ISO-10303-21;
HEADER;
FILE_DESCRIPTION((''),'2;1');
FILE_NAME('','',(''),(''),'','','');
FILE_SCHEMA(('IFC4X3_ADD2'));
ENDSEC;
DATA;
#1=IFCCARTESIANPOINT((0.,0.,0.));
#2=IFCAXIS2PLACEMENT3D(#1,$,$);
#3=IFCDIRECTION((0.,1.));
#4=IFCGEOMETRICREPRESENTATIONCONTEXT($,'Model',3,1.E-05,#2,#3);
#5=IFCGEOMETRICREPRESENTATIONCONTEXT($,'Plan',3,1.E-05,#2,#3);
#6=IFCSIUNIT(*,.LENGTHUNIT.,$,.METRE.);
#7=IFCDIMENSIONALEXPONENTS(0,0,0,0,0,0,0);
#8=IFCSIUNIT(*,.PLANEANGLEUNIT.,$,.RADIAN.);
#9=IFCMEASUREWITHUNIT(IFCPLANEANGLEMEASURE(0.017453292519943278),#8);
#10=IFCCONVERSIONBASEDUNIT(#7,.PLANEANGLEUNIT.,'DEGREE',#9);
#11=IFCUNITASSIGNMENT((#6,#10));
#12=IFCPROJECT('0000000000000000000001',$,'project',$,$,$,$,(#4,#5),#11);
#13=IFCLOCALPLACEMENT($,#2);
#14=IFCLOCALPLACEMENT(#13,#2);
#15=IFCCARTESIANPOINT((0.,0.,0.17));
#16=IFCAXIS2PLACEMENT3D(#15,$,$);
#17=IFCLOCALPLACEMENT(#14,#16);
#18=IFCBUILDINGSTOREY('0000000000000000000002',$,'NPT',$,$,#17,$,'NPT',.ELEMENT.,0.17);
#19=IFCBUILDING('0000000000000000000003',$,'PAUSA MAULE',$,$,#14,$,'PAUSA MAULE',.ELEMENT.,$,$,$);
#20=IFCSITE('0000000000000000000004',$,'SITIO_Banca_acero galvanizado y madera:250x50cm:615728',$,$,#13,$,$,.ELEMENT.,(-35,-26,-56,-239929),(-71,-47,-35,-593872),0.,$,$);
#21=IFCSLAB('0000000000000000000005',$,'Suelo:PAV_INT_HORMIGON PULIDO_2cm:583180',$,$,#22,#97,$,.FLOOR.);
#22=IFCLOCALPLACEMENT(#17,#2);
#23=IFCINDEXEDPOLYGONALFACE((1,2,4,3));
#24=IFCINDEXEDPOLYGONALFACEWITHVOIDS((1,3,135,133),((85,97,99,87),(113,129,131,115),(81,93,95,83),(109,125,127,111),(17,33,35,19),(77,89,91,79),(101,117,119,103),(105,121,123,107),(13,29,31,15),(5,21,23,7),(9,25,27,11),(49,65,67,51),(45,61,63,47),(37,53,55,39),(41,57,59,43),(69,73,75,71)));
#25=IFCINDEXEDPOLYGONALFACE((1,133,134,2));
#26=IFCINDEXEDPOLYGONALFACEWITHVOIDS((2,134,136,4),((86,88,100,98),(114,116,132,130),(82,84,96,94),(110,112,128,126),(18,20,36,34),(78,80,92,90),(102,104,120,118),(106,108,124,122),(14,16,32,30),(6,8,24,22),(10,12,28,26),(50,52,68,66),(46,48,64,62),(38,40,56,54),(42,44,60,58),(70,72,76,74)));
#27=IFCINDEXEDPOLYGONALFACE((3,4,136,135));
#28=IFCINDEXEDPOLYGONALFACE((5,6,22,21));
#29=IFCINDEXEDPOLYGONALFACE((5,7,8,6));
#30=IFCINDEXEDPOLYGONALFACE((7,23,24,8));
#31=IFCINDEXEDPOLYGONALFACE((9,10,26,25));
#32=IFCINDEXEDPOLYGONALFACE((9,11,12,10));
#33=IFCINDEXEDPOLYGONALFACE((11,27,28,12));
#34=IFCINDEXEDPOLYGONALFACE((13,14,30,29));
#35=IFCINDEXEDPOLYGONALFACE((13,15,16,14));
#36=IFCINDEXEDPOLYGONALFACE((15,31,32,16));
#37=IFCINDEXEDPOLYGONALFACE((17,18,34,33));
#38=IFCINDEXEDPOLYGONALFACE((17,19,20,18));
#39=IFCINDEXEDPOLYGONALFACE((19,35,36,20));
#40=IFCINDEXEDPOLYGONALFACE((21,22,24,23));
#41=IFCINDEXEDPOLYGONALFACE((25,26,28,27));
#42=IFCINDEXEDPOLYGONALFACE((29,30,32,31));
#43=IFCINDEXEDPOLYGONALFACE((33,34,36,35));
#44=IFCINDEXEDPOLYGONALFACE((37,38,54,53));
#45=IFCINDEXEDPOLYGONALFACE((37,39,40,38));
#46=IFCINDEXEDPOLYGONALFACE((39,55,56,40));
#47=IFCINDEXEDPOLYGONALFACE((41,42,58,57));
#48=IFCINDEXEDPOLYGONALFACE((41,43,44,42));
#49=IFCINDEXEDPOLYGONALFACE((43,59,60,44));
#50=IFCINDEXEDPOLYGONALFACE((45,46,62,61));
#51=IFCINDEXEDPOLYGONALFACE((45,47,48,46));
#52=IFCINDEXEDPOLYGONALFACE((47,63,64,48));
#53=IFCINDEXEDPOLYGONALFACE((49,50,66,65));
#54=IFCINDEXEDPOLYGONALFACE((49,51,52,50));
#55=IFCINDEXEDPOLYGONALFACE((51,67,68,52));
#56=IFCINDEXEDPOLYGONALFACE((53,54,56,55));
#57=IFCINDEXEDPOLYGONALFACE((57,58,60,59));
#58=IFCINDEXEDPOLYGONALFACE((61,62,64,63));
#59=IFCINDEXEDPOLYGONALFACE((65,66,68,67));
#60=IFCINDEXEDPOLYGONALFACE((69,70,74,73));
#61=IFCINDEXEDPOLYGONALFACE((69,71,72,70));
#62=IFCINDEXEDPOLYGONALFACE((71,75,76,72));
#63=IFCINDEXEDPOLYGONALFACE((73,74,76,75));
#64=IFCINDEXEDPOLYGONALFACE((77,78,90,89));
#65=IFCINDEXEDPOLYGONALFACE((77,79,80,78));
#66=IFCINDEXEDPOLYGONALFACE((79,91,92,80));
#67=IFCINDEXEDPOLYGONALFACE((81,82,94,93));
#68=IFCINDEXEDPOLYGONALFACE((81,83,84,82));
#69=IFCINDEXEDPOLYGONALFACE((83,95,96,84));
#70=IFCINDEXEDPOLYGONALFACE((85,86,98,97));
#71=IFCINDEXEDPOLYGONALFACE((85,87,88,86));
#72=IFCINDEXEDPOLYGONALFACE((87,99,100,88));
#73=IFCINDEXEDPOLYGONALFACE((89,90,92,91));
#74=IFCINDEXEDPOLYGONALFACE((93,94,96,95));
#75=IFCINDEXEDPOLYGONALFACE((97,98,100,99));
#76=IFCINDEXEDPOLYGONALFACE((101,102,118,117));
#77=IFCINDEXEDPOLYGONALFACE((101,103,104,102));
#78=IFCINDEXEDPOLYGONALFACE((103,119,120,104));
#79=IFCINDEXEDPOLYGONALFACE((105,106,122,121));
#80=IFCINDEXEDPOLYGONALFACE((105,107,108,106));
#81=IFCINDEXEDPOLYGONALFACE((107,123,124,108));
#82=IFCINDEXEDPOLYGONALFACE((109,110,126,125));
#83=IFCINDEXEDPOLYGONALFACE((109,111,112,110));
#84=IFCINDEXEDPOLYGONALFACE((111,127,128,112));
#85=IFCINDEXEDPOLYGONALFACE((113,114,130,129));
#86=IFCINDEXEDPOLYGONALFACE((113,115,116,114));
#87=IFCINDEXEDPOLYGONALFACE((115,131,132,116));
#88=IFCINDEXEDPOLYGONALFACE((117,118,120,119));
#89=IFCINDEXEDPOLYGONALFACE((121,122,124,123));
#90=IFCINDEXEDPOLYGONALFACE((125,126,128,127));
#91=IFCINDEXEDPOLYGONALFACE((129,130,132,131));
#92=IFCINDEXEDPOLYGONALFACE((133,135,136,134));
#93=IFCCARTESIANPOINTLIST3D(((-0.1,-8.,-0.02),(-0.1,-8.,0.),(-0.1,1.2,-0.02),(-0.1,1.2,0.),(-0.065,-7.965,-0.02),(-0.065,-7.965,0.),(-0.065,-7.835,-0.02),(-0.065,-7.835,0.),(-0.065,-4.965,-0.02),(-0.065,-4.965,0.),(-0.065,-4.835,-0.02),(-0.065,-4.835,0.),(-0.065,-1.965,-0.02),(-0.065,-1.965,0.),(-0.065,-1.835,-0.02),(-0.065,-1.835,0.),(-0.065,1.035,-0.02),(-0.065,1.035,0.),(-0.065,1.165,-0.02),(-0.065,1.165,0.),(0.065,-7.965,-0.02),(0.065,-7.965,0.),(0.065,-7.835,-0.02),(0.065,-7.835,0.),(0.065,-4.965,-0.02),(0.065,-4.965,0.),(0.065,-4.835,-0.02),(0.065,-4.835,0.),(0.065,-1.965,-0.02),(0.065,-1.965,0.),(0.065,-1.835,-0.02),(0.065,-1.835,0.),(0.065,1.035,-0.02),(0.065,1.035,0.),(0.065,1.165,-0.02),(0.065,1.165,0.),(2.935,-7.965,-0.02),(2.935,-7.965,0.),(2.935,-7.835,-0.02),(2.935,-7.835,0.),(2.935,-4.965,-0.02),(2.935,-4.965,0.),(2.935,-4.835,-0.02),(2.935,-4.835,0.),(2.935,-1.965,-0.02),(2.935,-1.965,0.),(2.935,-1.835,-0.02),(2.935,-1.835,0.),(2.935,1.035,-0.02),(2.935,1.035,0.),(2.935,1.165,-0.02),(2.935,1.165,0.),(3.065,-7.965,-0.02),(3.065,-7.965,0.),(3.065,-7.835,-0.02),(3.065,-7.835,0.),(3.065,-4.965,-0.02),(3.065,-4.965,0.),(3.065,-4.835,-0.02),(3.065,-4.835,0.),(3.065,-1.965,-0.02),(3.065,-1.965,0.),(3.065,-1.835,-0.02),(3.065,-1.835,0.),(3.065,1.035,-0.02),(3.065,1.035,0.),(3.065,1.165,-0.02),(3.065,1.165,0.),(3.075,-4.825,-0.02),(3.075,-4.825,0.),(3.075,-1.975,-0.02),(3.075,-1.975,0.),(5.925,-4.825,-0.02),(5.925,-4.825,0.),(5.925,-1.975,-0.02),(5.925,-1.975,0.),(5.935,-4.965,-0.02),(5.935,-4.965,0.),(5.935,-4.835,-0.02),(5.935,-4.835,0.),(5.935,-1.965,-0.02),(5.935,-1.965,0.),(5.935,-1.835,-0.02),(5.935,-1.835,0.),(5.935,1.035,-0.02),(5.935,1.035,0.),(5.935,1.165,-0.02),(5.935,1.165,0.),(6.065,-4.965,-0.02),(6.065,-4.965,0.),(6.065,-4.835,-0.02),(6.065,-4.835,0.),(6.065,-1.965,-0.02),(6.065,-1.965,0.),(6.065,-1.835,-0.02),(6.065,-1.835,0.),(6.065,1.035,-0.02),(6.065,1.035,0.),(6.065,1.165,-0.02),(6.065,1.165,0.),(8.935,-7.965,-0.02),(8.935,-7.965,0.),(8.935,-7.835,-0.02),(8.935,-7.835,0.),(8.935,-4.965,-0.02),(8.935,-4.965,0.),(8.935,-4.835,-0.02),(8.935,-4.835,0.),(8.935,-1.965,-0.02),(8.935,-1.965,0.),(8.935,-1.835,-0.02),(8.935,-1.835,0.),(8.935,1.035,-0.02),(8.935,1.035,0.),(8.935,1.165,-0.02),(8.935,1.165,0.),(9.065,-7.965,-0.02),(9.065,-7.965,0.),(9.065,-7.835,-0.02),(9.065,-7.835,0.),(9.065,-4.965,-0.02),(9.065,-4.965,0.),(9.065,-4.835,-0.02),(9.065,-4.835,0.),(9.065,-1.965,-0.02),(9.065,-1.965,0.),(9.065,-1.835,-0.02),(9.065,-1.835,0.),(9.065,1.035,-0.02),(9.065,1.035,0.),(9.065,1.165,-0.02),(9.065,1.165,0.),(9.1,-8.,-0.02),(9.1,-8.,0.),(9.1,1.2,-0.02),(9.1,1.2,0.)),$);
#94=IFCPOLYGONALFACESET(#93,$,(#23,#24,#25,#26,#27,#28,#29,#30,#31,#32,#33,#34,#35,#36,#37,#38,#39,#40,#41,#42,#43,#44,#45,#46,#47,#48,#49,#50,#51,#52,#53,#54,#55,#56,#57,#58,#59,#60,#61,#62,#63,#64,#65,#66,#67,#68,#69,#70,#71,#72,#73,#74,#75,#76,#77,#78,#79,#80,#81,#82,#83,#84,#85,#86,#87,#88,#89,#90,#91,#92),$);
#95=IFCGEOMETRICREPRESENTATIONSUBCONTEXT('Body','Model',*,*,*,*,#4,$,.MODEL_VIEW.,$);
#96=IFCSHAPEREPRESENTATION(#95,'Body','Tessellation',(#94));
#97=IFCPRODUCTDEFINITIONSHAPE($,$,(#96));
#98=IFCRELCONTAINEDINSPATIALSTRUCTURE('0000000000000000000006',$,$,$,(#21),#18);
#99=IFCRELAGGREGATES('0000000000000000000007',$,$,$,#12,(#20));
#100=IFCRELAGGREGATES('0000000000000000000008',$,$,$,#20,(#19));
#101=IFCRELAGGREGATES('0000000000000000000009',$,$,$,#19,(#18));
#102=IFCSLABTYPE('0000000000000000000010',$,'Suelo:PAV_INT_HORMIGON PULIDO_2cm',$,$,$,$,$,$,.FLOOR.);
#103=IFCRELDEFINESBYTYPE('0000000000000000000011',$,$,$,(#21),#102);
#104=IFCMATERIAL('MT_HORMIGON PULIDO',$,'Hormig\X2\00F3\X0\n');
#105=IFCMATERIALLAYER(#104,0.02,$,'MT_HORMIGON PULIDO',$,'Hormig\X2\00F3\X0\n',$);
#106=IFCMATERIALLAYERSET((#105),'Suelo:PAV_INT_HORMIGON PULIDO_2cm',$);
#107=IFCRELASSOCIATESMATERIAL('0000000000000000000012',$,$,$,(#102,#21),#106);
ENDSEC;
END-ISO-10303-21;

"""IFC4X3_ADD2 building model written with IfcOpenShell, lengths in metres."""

from ifc_helpers import new_model, entity, si_unit, converted_unit, direction, frame, frame_2d, origin, origin_2d_with_axis, place, context, subcontext, project, spatial, rectangle, extrude, boolean, material, layer, layer_set, layer_usage, type_object, element, save


model = new_model("IFC4X3_ADD2")

# Units and contexts
model_context = context("Model", 3, precision=1e-05, world=origin(), true_north=direction((0.0, 1.0)))
plan_context = context("Plan", 3, precision=1e-05, world=origin(), true_north=direction((0.0, 1.0)))
body_context = subcontext(model_context, "Body", "Model", "MODEL_VIEW")
ifc_project = project(units=[si_unit("LENGTHUNIT", "METRE"), converted_unit("PLANEANGLEUNIT", "DEGREE", entity("IfcPlaneAngleMeasure", 0.017453292519943278), si_unit("PLANEANGLEUNIT", "RADIAN"), dimensions=[0, 0, 0, 0, 0, 0, 0])], contexts=[model_context, plan_context])

# Site, building, storey
site_placement = place(None, origin())
site = spatial("IfcSite", under=ifc_project, at=site_placement, Name="SITIO_Banca_acero galvanizado y madera:250x50cm:615728", CompositionType="ELEMENT", RefLatitude=(-35, -26, -56, -239929), RefLongitude=(-71, -47, -35, -593872), RefElevation=0.0)
building_placement = place(site_placement, origin())
building = spatial("IfcBuilding", under=site, at=building_placement, Name="PAUSA MAULE", LongName="PAUSA MAULE", CompositionType="ELEMENT")
storey_placement = place(building_placement, frame((0.0, 0.0, 0.17)))
storey = spatial("IfcBuildingStorey", under=building, at=storey_placement, Name="NPT", LongName="NPT", CompositionType="ELEMENT", Elevation=0.17)

# Slab, opening
ifc_material_1 = material(Name="MT_HORMIGON PULIDO", Category="Hormigón")
ifc_layer = layer(ifc_material_1, 0.02, Name="MT_HORMIGON PULIDO", Category="Hormigón")
ifc_layer_set = layer_set([ifc_layer], Name="Suelo:PAV_INT_HORMIGON PULIDO_2cm")
ifc_layer_usage = layer_usage(ifc_layer_set, "AXIS3", "POSITIVE", 0.0)
slab_type = type_object("IfcSlabType", Name="Suelo:PAV_INT_HORMIGON PULIDO_2cm", PredefinedType="FLOOR", material=ifc_layer_set)
slab_placement = place(storey_placement, origin())
solid = boolean("DIFFERENCE", boolean("DIFFERENCE", boolean("DIFFERENCE", boolean("DIFFERENCE", boolean("DIFFERENCE", boolean("DIFFERENCE", boolean("DIFFERENCE", boolean("DIFFERENCE", extrude(rectangle(XDim=9.2, YDim=9.2, at=origin_2d_with_axis()), frame((4.5, -3.4, 0.0), z_axis=(0.0, 0.0, -1.0), x_axis=(0.0, 1.0, 0.0)), (0.0, 0.0, 1.0), 0.02), extrude(rectangle(XDim=2.85, YDim=2.85, at=origin_2d_with_axis()), frame((4.5, -3.4, -0.02), z_axis=(0.0, 0.0, 1.0), x_axis=(0.0, 1.0, 0.0)), (0.0, 0.0, 1.0), 0.02)), extrude(rectangle(XDim=0.13, YDim=0.13, at=origin_2d_with_axis()), frame((3.0, -4.9, -0.02), z_axis=(0.0, 0.0, 1.0), x_axis=(0.0, 1.0, 0.0)), (0.0, 0.0, 1.0), 0.02)), extrude(rectangle(XDim=0.13, YDim=0.13, at=origin_2d_with_axis()), frame((3.0, -1.9, -0.02), z_axis=(0.0, 0.0, 1.0), x_axis=(0.0, 1.0, 0.0)), (0.0, 0.0, 1.0), 0.02)), extrude(rectangle(XDim=0.13, YDim=0.13, at=frame_2d((0.0, 0.0), x_axis=(1.0, 0.0))), frame((6.0, -4.9, -0.02), z_axis=(0.0, 0.0, 1.0), x_axis=(0.0, 1.0, 0.0)), (0.0, 0.0, 1.0), 0.02)), extrude(rectangle(XDim=0.13, YDim=0.13, at=frame_2d((0.0, 0.0), x_axis=(1.0, 0.0))), frame((6.0, -1.9, -0.02), z_axis=(0.0, 0.0, 1.0), x_axis=(0.0, 1.0, 0.0)), (0.0, 0.0, 1.0), 0.02)), extrude(rectangle(XDim=0.13, YDim=0.13, at=origin_2d_with_axis()), frame((0.0, -7.9, -0.02), z_axis=(0.0, 0.0, 1.0), x_axis=(0.0, 1.0, 0.0)), (0.0, 0.0, 1.0), 0.02)), extrude(rectangle(XDim=0.13, YDim=0.13, at=origin_2d_with_axis()), frame((0.0, -4.9, -0.02), z_axis=(0.0, 0.0, 1.0), x_axis=(0.0, 1.0, 0.0)), (0.0, 0.0, 1.0), 0.02)), extrude(rectangle(XDim=0.13, YDim=0.13, at=origin_2d_with_axis()), frame((0.0, -1.9, -0.02), z_axis=(0.0, 0.0, 1.0), x_axis=(0.0, 1.0, 0.0)), (0.0, 0.0, 1.0), 0.02))
slab = element("IfcSlab", 1, at=slab_placement, inside=storey, type_object=slab_type, material=ifc_layer_usage, Name="Suelo:PAV_INT_HORMIGON PULIDO_2cm:583180", PredefinedType="FLOOR", context=body_context, shape_type="CSG", body=[
    boolean("DIFFERENCE", boolean("DIFFERENCE", boolean("DIFFERENCE", boolean("DIFFERENCE", boolean("DIFFERENCE", boolean("DIFFERENCE", boolean("DIFFERENCE", boolean("DIFFERENCE", solid, extrude(rectangle(XDim=0.13, YDim=0.13, at=origin_2d_with_axis()), frame((0.0, 1.1, -0.02), z_axis=(0.0, 0.0, 1.0), x_axis=(0.0, 1.0, 0.0)), (0.0, 0.0, 1.0), 0.02)), extrude(rectangle(XDim=0.13, YDim=0.13, at=origin_2d_with_axis()), frame((3.0, -7.9, -0.02), z_axis=(0.0, 0.0, 1.0), x_axis=(0.0, 1.0, 0.0)), (0.0, 0.0, 1.0), 0.02)), extrude(rectangle(XDim=0.13, YDim=0.13, at=origin_2d_with_axis()), frame((3.0, 1.1, -0.02), z_axis=(0.0, 0.0, 1.0), x_axis=(0.0, 1.0, 0.0)), (0.0, 0.0, 1.0), 0.02)), extrude(rectangle(XDim=0.13, YDim=0.13, at=frame_2d((0.0, 0.0), x_axis=(1.0, 0.0))), frame((6.0, 1.1, -0.02), z_axis=(0.0, 0.0, 1.0), x_axis=(0.0, 1.0, 0.0)), (0.0, 0.0, 1.0), 0.02)), extrude(rectangle(XDim=0.13, YDim=0.13, at=frame_2d((0.0, 0.0), x_axis=(1.0, 0.0))), frame((9.0, -7.9, -0.02), z_axis=(0.0, 0.0, 1.0), x_axis=(0.0, 1.0, 0.0)), (0.0, 0.0, 1.0), 0.02)), extrude(rectangle(XDim=0.13, YDim=0.13, at=frame_2d((0.0, 0.0), x_axis=(1.0, 0.0))), frame((9.0, -4.9, -0.02), z_axis=(0.0, 0.0, 1.0), x_axis=(0.0, 1.0, 0.0)), (0.0, 0.0, 1.0), 0.02)), extrude(rectangle(XDim=0.13, YDim=0.13, at=frame_2d((0.0, 0.0), x_axis=(1.0, 0.0))), frame((9.0, -1.9, -0.02), z_axis=(0.0, 0.0, 1.0), x_axis=(0.0, 1.0, 0.0)), (0.0, 0.0, 1.0), 0.02)), extrude(rectangle(XDim=0.13, YDim=0.13, at=frame_2d((0.0, 0.0), x_axis=(1.0, 0.0))), frame((9.0, 1.1, -0.02), z_axis=(0.0, 0.0, 1.0), x_axis=(0.0, 1.0, 0.0)), (0.0, 0.0, 1.0), 0.02)),
])
opening_placement = place(slab_placement, origin())
element("IfcOpeningElement", 2, at=opening_placement, cuts=slab, PredefinedType="OPENING", context=body_context, shape_type="SweptSolid", body=[
    extrude(rectangle(XDim=2.85, YDim=2.85, at=frame_2d((4.5, -3.4), x_axis=(0.0, -1.0))), origin(), (0.0, 0.0, -1.0), 0.02),
])

save(model, "model.ifc")
